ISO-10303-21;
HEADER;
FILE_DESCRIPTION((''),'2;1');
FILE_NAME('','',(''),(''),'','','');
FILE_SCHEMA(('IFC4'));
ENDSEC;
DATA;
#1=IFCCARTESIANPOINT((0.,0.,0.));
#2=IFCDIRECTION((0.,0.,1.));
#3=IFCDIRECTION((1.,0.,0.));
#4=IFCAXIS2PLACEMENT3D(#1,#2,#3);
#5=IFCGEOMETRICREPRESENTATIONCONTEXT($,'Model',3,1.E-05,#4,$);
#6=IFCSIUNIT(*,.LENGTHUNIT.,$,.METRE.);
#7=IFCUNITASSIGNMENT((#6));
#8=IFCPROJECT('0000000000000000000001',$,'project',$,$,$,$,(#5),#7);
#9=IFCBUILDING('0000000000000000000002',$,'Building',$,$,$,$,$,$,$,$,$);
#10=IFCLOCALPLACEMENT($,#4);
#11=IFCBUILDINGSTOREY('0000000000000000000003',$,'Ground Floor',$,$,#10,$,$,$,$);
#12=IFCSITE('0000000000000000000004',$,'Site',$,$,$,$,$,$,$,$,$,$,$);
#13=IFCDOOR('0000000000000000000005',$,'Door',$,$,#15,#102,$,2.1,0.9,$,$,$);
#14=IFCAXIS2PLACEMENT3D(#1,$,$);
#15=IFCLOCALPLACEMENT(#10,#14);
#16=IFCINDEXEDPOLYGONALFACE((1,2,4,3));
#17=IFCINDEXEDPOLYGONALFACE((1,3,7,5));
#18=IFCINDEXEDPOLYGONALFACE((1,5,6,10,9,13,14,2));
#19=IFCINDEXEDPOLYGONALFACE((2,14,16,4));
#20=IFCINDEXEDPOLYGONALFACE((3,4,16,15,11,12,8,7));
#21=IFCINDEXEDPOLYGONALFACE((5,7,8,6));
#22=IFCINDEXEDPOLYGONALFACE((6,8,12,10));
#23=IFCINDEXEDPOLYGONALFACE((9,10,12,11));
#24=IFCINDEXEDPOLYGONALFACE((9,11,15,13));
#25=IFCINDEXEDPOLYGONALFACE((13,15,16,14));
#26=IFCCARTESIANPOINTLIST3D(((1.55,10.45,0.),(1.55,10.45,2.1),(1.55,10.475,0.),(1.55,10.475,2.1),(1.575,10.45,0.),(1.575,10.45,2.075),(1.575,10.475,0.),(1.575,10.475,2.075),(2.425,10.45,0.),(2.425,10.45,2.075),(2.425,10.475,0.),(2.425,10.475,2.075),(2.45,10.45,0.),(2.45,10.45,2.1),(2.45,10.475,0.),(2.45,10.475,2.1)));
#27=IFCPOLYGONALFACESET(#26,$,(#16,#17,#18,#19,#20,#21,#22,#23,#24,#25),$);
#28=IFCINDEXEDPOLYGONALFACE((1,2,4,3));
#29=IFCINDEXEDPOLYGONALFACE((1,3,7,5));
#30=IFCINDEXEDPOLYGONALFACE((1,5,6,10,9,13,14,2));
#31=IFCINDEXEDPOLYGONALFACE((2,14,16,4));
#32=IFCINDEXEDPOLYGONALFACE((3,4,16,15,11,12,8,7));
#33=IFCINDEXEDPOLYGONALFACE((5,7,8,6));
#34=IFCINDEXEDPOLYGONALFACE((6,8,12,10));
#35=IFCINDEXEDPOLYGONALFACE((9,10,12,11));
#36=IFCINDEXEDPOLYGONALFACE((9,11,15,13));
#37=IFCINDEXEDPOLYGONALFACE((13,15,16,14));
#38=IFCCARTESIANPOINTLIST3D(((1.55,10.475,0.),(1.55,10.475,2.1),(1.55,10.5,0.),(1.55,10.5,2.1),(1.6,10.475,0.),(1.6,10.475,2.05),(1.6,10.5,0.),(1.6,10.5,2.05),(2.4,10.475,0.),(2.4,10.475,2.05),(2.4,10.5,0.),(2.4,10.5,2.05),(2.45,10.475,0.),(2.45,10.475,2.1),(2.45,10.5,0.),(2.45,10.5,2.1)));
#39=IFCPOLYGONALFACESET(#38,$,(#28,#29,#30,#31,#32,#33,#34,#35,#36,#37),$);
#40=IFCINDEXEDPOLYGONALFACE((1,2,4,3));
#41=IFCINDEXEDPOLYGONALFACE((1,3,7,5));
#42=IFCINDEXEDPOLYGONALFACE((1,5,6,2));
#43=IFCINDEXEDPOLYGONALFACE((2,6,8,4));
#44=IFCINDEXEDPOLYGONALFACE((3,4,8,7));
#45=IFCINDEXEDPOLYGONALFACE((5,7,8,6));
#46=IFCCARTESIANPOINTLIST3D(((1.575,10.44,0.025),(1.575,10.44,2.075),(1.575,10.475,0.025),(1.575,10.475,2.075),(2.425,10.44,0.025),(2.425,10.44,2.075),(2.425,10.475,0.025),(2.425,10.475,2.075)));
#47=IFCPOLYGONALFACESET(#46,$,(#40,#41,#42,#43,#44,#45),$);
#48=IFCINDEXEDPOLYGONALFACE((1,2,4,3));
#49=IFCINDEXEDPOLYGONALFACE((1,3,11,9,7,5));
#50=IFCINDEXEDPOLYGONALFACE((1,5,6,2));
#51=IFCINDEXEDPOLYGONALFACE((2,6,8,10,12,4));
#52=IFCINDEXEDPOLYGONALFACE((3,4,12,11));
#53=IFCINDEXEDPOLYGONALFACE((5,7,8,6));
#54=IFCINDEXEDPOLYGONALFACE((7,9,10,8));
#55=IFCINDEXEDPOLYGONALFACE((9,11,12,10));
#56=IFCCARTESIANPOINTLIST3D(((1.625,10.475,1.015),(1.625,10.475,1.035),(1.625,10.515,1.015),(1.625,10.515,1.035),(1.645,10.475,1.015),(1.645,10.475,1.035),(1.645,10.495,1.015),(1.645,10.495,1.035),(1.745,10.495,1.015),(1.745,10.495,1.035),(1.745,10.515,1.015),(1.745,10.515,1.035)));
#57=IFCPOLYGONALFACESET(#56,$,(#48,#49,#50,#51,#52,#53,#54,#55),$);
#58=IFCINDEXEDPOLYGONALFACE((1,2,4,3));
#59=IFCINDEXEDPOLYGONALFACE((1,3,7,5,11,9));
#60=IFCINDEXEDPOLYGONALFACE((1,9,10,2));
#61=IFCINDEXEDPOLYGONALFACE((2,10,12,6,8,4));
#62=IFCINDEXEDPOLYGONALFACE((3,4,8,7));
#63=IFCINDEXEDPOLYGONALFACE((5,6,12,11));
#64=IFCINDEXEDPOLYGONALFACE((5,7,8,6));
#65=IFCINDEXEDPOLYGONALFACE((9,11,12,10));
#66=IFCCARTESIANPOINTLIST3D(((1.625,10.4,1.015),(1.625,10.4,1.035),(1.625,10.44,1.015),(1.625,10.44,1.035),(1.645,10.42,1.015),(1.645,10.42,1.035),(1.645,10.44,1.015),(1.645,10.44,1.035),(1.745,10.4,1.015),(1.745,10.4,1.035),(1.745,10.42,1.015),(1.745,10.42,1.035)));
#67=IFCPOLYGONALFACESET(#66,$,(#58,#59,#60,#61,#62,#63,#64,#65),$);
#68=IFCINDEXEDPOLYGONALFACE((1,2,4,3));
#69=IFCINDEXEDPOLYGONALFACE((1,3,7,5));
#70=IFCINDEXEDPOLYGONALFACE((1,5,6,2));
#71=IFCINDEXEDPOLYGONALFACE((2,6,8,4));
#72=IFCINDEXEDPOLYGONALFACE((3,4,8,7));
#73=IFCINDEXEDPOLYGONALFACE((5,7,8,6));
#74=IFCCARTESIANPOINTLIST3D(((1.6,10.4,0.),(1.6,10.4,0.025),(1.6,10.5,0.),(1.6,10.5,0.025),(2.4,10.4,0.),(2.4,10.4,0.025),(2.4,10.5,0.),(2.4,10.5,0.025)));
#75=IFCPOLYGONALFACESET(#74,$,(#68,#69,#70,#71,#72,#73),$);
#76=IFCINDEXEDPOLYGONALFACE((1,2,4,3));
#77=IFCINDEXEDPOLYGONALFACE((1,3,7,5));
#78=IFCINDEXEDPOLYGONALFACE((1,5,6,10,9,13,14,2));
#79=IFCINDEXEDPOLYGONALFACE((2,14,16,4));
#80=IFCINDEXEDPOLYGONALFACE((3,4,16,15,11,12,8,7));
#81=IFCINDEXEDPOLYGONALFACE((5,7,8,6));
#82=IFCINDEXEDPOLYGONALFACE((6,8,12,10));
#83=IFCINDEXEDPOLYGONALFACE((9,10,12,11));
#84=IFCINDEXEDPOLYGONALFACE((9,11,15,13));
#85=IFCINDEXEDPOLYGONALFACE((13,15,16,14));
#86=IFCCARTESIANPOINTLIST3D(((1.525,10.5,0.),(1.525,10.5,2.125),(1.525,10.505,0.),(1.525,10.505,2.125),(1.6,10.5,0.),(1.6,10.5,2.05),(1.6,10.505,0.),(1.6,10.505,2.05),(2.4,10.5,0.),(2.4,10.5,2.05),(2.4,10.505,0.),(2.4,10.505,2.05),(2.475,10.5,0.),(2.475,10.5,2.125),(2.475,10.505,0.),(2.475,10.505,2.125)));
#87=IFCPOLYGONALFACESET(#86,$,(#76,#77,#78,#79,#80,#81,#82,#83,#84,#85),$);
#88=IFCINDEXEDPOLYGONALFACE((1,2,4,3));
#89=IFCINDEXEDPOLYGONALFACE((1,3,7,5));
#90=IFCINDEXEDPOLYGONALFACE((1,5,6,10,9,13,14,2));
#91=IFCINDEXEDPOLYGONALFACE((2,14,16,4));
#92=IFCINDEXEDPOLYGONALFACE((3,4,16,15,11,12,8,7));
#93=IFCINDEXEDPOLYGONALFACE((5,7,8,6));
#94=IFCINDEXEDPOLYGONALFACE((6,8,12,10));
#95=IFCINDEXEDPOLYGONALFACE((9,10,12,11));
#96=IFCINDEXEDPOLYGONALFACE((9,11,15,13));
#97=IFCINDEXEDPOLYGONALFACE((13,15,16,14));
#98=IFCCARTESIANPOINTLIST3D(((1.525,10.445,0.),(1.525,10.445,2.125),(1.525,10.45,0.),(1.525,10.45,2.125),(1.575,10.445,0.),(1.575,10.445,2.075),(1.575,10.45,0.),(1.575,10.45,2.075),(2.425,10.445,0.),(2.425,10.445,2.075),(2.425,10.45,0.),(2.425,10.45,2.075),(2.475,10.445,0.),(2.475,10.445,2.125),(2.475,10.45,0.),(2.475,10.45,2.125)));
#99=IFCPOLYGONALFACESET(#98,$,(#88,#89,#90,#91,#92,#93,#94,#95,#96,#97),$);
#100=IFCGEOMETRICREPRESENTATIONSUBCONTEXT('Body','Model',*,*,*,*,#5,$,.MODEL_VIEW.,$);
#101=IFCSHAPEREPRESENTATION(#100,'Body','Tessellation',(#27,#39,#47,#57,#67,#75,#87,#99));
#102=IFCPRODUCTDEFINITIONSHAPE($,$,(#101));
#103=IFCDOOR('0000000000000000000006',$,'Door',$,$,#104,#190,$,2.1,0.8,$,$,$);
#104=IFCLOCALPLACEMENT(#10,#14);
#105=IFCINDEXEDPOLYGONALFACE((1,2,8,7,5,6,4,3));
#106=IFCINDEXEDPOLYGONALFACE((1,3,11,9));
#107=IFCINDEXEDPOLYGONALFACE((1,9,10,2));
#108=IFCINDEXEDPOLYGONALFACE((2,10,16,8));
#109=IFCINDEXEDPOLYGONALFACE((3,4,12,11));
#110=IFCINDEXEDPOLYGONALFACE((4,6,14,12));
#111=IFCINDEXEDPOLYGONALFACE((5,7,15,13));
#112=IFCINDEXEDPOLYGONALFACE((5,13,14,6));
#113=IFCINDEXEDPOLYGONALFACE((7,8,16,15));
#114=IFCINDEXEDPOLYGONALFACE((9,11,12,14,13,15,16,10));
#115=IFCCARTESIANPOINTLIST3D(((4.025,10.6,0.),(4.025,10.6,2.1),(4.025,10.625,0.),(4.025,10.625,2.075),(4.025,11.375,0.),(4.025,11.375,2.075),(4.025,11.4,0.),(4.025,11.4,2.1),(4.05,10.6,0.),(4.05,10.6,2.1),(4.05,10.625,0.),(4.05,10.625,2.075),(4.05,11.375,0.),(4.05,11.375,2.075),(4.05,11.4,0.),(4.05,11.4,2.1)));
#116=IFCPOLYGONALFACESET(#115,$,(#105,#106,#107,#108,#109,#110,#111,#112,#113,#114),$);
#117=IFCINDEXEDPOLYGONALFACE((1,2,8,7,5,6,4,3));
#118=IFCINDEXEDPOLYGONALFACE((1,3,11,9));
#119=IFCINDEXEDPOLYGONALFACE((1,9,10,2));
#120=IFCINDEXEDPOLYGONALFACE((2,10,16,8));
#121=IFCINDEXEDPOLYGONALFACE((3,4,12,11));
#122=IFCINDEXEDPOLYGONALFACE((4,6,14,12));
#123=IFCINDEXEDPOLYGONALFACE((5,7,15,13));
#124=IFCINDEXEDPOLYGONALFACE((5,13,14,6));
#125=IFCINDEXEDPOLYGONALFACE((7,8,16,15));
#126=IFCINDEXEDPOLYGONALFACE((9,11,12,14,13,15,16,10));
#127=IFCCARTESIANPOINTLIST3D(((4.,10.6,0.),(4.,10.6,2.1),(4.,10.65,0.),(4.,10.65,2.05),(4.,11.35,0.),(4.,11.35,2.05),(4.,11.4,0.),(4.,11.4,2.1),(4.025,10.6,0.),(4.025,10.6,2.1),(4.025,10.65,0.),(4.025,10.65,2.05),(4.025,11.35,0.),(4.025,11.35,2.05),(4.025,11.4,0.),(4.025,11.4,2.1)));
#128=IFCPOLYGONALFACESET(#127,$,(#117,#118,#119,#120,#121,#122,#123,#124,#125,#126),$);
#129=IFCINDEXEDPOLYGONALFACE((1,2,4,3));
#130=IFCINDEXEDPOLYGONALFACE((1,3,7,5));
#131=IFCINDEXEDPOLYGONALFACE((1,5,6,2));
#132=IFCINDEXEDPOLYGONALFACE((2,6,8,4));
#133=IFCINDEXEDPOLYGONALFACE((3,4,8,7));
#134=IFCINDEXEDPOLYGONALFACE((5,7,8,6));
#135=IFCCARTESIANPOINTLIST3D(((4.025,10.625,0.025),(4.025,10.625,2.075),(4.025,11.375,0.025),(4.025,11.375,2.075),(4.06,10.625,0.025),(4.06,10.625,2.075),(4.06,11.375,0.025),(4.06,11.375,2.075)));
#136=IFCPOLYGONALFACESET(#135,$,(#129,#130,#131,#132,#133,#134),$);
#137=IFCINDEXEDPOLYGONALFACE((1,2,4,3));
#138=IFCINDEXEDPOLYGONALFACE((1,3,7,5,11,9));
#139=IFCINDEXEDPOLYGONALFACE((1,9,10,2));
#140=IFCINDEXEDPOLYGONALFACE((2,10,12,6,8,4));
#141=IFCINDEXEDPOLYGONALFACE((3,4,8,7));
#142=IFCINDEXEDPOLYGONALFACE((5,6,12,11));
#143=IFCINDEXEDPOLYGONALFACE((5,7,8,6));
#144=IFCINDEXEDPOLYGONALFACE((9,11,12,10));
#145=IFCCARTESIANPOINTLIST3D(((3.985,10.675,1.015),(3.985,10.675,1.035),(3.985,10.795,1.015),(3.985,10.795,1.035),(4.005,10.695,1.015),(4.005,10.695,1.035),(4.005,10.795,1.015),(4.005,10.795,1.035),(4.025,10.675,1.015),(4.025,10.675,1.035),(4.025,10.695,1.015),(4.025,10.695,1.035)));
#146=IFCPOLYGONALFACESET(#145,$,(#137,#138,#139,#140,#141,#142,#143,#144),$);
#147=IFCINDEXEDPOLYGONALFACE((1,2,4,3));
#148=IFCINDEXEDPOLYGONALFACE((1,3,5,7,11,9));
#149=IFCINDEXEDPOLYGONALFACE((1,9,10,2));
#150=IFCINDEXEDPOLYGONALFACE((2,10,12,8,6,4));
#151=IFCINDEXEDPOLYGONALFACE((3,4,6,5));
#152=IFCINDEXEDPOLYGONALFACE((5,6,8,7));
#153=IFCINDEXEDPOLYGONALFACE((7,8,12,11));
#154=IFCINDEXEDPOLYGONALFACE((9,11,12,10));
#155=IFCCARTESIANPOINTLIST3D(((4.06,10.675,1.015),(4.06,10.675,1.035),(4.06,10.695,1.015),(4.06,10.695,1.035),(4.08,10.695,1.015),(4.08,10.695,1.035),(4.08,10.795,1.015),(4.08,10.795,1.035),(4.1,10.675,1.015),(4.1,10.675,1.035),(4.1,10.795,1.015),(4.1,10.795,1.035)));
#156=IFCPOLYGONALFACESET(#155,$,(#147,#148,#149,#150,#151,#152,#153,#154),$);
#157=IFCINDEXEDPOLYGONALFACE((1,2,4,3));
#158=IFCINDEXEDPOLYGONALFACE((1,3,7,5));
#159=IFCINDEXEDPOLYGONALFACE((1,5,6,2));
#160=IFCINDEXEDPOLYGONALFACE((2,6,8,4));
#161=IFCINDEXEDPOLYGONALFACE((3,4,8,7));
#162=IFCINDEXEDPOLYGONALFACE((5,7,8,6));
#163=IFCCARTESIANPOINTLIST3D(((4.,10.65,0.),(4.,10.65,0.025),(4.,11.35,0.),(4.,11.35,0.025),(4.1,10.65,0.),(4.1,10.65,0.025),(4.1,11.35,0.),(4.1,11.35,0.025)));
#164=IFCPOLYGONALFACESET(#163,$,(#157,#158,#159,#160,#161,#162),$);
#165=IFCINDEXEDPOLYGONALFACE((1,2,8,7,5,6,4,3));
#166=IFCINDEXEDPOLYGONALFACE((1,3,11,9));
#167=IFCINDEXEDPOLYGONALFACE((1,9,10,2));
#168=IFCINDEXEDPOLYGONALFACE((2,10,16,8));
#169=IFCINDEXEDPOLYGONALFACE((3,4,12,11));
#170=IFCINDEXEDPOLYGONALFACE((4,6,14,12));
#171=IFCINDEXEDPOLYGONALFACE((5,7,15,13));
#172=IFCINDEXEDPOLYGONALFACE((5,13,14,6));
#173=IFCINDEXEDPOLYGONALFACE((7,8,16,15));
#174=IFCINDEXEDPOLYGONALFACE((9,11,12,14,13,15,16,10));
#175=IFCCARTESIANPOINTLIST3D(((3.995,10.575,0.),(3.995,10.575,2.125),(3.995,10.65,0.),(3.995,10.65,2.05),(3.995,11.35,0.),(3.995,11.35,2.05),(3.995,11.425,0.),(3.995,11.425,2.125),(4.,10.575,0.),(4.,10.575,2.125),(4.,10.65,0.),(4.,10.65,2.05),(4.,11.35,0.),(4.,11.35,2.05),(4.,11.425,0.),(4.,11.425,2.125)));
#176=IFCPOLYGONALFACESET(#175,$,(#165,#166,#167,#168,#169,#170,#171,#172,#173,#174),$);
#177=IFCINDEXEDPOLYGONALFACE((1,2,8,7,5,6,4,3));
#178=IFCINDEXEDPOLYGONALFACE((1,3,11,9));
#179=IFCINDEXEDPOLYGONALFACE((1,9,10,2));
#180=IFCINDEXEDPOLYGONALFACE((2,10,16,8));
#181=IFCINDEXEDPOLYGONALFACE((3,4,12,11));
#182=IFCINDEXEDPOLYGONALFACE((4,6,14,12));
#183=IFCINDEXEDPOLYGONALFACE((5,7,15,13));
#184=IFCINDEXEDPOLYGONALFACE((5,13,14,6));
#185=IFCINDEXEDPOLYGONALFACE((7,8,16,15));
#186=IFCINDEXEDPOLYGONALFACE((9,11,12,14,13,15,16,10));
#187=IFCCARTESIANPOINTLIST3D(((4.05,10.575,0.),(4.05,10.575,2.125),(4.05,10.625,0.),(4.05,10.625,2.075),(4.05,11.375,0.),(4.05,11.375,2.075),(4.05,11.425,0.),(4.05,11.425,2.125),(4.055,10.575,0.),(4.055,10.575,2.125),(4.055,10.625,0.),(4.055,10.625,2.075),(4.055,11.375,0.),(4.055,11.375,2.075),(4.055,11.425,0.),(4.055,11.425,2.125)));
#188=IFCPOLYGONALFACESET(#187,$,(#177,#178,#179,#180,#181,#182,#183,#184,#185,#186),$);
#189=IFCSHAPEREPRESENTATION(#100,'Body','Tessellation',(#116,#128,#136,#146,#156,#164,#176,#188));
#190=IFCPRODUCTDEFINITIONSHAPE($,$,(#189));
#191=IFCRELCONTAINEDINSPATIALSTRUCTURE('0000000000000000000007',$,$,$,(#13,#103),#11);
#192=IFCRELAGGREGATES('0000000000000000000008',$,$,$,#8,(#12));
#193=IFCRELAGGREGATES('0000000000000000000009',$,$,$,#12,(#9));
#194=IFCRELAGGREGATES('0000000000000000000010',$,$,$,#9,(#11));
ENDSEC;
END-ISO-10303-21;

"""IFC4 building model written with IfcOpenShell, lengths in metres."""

from ifc_helpers import new_model, si_unit, frame, origin_with_axes, place, context, subcontext, project, spatial, line, indexed_curve, outline, extrude, element, save


model = new_model("IFC4")

# Units and contexts
model_context = context("Model", 3, precision=1e-05, world=origin_with_axes())
body_context = subcontext(model_context, "Body", "Model", "MODEL_VIEW")
ifc_project = project(units=[si_unit("LENGTHUNIT", "METRE")], contexts=[model_context])

# Site, building, storey
site = spatial("IfcSite", under=ifc_project, Name="Site")
building = spatial("IfcBuilding", under=site, Name="Building")
storey_placement = place(None, origin_with_axes())
storey = spatial("IfcBuildingStorey", under=building, at=storey_placement, Name="Ground Floor")

# Doors
door_1_placement = place(storey_placement, frame((2.45, 10.5, 0.0), z_axis=(0.0, 0.0, 1.0), x_axis=(-1.0, 0.0, 0.0)))
element("IfcDoor", 1, at=door_1_placement, inside=storey, Name="Door", OverallHeight=2.1, OverallWidth=0.9, context=body_context, shape_type="SweptSolid", body=[
    extrude(outline(indexed_curve([(0.0, 0.0), (0.0, 2.1), (0.9, 2.1), (0.9, 0.0), (0.875, 0.0), (0.875, 2.075), (0.025, 2.075), (0.025, 0.0)], segments=[line(1, 2, 3, 4, 5, 6, 7, 8, 1)])), frame((0.0, 0.025, 0.0), z_axis=(0.0, -1.0, 0.0), x_axis=(1.0, 0.0, 0.0)), (0.0, 0.0, -1.0), 0.025),
    extrude(outline(indexed_curve([(0.0, 0.0), (0.0, 2.1), (0.9, 2.1), (0.9, 0.0), (0.85, 0.0), (0.85, 2.05), (0.05, 2.05), (0.05, 0.0)], segments=[line(1, 2, 3, 4, 5, 6, 7, 8, 1)])), frame((0.0, 0.0, 0.0), z_axis=(0.0, -1.0, 0.0), x_axis=(1.0, 0.0, 0.0)), (0.0, 0.0, -1.0), 0.025),
    extrude(outline(indexed_curve([(0.0, 0.0), (0.85, 0.0), (0.85, 0.035), (0.0, 0.035)], segments=[line(1, 2, 3, 4, 1)])), frame((0.025, 0.025, 0.025), z_axis=(0.0, 0.0, 1.0), x_axis=(1.0, 0.0, 0.0)), (0.0, 0.0, 1.0), 2.05),
    extrude(outline(indexed_curve([(0.0, 0.0), (0.0, -0.04), (-0.12, -0.04), (-0.12, -0.02), (-0.02, -0.02), (-0.02, 0.0)], segments=[line(1, 2, 3, 4, 5, 6, 1)])), frame((0.825, 0.025, 1.015), z_axis=(0.0, 0.0, 1.0), x_axis=(1.0, 0.0, 0.0)), (0.0, 0.0, 1.0), 0.02),
    extrude(outline(indexed_curve([(0.0, 0.0), (0.0, 0.04), (-0.12, 0.04), (-0.12, 0.02), (-0.02, 0.02), (-0.02, 0.0)], segments=[line(1, 2, 3, 4, 5, 6, 1)])), frame((0.825, 0.06, 1.015), z_axis=(0.0, 0.0, 1.0), x_axis=(1.0, 0.0, 0.0)), (0.0, 0.0, 1.0), 0.02),
    extrude(outline(indexed_curve([(0.0, 0.0), (0.8, 0.0), (0.8, 0.1), (0.0, 0.1)], segments=[line(1, 2, 3, 4, 1)])), frame((0.05, 0.0, 0.0), z_axis=(0.0, 0.0, 1.0), x_axis=(1.0, 0.0, 0.0)), (0.0, 0.0, 1.0), 0.025),
    extrude(outline(indexed_curve([(0.0, 0.0), (0.0, 2.125), (0.95, 2.125), (0.95, 0.0), (0.875, 0.0), (0.875, 2.05), (0.075, 2.05), (0.075, 0.0)], segments=[line(1, 2, 3, 4, 5, 6, 7, 8, 1)])), frame((-0.025, -0.005, 0.0), z_axis=(0.0, -1.0, 0.0), x_axis=(1.0, 0.0, 0.0)), (0.0, 0.0, -1.0), 0.005),
    extrude(outline(indexed_curve([(0.0, 0.0), (0.0, 2.125), (0.95, 2.125), (0.95, 0.0), (0.9, 0.0), (0.9, 2.075), (0.05, 2.075), (0.05, 0.0)], segments=[line(1, 2, 3, 4, 5, 6, 7, 8, 1)])), frame((-0.025, 0.05, 0.0), z_axis=(0.0, -1.0, 0.0), x_axis=(1.0, 0.0, 0.0)), (0.0, 0.0, -1.0), 0.005),
])
door_2_placement = place(storey_placement, frame((4.0, 11.4, 0.0), z_axis=(0.0, 0.0, 1.0), x_axis=(0.0, -1.0, 0.0)))
element("IfcDoor", 2, at=door_2_placement, inside=storey, Name="Door", OverallHeight=2.1, OverallWidth=0.8, context=body_context, shape_type="SweptSolid", body=[
    extrude(outline(indexed_curve([(0.0, 0.0), (0.0, 2.1), (0.8, 2.1), (0.8, 0.0), (0.775, 0.0), (0.775, 2.075), (0.025, 2.075), (0.025, 0.0)], segments=[line(1, 2, 3, 4, 5, 6, 7, 8, 1)])), frame((0.0, 0.025, 0.0), z_axis=(0.0, -1.0, 0.0), x_axis=(1.0, 0.0, 0.0)), (0.0, 0.0, -1.0), 0.025),
    extrude(outline(indexed_curve([(0.0, 0.0), (0.0, 2.1), (0.8, 2.1), (0.8, 0.0), (0.75, 0.0), (0.75, 2.05), (0.05, 2.05), (0.05, 0.0)], segments=[line(1, 2, 3, 4, 5, 6, 7, 8, 1)])), frame((0.0, 0.0, 0.0), z_axis=(0.0, -1.0, 0.0), x_axis=(1.0, 0.0, 0.0)), (0.0, 0.0, -1.0), 0.025),
    extrude(outline(indexed_curve([(0.0, 0.0), (0.75, 0.0), (0.75, 0.035), (0.0, 0.035)], segments=[line(1, 2, 3, 4, 1)])), frame((0.025, 0.025, 0.025), z_axis=(0.0, 0.0, 1.0), x_axis=(1.0, 0.0, 0.0)), (0.0, 0.0, 1.0), 2.05),
    extrude(outline(indexed_curve([(0.0, 0.0), (0.0, -0.04), (-0.12, -0.04), (-0.12, -0.02), (-0.02, -0.02), (-0.02, 0.0)], segments=[line(1, 2, 3, 4, 5, 6, 1)])), frame((0.725, 0.025, 1.015), z_axis=(0.0, 0.0, 1.0), x_axis=(1.0, 0.0, 0.0)), (0.0, 0.0, 1.0), 0.02),
    extrude(outline(indexed_curve([(0.0, 0.0), (0.0, 0.04), (-0.12, 0.04), (-0.12, 0.02), (-0.02, 0.02), (-0.02, 0.0)], segments=[line(1, 2, 3, 4, 5, 6, 1)])), frame((0.725, 0.06, 1.015), z_axis=(0.0, 0.0, 1.0), x_axis=(1.0, 0.0, 0.0)), (0.0, 0.0, 1.0), 0.02),
    extrude(outline(indexed_curve([(0.0, 0.0), (0.7, 0.0), (0.7, 0.1), (0.0, 0.1)], segments=[line(1, 2, 3, 4, 1)])), frame((0.05, 0.0, 0.0), z_axis=(0.0, 0.0, 1.0), x_axis=(1.0, 0.0, 0.0)), (0.0, 0.0, 1.0), 0.025),
    extrude(outline(indexed_curve([(0.0, 0.0), (0.0, 2.125), (0.85, 2.125), (0.85, 0.0), (0.775, 0.0), (0.775, 2.05), (0.075, 2.05), (0.075, 0.0)], segments=[line(1, 2, 3, 4, 5, 6, 7, 8, 1)])), frame((-0.025, -0.005, 0.0), z_axis=(0.0, -1.0, 0.0), x_axis=(1.0, 0.0, 0.0)), (0.0, 0.0, -1.0), 0.005),
    extrude(outline(indexed_curve([(0.0, 0.0), (0.0, 2.125), (0.85, 2.125), (0.85, 0.0), (0.8, 0.0), (0.8, 2.075), (0.05, 2.075), (0.05, 0.0)], segments=[line(1, 2, 3, 4, 5, 6, 7, 8, 1)])), frame((-0.025, 0.05, 0.0), z_axis=(0.0, -1.0, 0.0), x_axis=(1.0, 0.0, 0.0)), (0.0, 0.0, -1.0), 0.005),
])

save(model, "model.ifc")
